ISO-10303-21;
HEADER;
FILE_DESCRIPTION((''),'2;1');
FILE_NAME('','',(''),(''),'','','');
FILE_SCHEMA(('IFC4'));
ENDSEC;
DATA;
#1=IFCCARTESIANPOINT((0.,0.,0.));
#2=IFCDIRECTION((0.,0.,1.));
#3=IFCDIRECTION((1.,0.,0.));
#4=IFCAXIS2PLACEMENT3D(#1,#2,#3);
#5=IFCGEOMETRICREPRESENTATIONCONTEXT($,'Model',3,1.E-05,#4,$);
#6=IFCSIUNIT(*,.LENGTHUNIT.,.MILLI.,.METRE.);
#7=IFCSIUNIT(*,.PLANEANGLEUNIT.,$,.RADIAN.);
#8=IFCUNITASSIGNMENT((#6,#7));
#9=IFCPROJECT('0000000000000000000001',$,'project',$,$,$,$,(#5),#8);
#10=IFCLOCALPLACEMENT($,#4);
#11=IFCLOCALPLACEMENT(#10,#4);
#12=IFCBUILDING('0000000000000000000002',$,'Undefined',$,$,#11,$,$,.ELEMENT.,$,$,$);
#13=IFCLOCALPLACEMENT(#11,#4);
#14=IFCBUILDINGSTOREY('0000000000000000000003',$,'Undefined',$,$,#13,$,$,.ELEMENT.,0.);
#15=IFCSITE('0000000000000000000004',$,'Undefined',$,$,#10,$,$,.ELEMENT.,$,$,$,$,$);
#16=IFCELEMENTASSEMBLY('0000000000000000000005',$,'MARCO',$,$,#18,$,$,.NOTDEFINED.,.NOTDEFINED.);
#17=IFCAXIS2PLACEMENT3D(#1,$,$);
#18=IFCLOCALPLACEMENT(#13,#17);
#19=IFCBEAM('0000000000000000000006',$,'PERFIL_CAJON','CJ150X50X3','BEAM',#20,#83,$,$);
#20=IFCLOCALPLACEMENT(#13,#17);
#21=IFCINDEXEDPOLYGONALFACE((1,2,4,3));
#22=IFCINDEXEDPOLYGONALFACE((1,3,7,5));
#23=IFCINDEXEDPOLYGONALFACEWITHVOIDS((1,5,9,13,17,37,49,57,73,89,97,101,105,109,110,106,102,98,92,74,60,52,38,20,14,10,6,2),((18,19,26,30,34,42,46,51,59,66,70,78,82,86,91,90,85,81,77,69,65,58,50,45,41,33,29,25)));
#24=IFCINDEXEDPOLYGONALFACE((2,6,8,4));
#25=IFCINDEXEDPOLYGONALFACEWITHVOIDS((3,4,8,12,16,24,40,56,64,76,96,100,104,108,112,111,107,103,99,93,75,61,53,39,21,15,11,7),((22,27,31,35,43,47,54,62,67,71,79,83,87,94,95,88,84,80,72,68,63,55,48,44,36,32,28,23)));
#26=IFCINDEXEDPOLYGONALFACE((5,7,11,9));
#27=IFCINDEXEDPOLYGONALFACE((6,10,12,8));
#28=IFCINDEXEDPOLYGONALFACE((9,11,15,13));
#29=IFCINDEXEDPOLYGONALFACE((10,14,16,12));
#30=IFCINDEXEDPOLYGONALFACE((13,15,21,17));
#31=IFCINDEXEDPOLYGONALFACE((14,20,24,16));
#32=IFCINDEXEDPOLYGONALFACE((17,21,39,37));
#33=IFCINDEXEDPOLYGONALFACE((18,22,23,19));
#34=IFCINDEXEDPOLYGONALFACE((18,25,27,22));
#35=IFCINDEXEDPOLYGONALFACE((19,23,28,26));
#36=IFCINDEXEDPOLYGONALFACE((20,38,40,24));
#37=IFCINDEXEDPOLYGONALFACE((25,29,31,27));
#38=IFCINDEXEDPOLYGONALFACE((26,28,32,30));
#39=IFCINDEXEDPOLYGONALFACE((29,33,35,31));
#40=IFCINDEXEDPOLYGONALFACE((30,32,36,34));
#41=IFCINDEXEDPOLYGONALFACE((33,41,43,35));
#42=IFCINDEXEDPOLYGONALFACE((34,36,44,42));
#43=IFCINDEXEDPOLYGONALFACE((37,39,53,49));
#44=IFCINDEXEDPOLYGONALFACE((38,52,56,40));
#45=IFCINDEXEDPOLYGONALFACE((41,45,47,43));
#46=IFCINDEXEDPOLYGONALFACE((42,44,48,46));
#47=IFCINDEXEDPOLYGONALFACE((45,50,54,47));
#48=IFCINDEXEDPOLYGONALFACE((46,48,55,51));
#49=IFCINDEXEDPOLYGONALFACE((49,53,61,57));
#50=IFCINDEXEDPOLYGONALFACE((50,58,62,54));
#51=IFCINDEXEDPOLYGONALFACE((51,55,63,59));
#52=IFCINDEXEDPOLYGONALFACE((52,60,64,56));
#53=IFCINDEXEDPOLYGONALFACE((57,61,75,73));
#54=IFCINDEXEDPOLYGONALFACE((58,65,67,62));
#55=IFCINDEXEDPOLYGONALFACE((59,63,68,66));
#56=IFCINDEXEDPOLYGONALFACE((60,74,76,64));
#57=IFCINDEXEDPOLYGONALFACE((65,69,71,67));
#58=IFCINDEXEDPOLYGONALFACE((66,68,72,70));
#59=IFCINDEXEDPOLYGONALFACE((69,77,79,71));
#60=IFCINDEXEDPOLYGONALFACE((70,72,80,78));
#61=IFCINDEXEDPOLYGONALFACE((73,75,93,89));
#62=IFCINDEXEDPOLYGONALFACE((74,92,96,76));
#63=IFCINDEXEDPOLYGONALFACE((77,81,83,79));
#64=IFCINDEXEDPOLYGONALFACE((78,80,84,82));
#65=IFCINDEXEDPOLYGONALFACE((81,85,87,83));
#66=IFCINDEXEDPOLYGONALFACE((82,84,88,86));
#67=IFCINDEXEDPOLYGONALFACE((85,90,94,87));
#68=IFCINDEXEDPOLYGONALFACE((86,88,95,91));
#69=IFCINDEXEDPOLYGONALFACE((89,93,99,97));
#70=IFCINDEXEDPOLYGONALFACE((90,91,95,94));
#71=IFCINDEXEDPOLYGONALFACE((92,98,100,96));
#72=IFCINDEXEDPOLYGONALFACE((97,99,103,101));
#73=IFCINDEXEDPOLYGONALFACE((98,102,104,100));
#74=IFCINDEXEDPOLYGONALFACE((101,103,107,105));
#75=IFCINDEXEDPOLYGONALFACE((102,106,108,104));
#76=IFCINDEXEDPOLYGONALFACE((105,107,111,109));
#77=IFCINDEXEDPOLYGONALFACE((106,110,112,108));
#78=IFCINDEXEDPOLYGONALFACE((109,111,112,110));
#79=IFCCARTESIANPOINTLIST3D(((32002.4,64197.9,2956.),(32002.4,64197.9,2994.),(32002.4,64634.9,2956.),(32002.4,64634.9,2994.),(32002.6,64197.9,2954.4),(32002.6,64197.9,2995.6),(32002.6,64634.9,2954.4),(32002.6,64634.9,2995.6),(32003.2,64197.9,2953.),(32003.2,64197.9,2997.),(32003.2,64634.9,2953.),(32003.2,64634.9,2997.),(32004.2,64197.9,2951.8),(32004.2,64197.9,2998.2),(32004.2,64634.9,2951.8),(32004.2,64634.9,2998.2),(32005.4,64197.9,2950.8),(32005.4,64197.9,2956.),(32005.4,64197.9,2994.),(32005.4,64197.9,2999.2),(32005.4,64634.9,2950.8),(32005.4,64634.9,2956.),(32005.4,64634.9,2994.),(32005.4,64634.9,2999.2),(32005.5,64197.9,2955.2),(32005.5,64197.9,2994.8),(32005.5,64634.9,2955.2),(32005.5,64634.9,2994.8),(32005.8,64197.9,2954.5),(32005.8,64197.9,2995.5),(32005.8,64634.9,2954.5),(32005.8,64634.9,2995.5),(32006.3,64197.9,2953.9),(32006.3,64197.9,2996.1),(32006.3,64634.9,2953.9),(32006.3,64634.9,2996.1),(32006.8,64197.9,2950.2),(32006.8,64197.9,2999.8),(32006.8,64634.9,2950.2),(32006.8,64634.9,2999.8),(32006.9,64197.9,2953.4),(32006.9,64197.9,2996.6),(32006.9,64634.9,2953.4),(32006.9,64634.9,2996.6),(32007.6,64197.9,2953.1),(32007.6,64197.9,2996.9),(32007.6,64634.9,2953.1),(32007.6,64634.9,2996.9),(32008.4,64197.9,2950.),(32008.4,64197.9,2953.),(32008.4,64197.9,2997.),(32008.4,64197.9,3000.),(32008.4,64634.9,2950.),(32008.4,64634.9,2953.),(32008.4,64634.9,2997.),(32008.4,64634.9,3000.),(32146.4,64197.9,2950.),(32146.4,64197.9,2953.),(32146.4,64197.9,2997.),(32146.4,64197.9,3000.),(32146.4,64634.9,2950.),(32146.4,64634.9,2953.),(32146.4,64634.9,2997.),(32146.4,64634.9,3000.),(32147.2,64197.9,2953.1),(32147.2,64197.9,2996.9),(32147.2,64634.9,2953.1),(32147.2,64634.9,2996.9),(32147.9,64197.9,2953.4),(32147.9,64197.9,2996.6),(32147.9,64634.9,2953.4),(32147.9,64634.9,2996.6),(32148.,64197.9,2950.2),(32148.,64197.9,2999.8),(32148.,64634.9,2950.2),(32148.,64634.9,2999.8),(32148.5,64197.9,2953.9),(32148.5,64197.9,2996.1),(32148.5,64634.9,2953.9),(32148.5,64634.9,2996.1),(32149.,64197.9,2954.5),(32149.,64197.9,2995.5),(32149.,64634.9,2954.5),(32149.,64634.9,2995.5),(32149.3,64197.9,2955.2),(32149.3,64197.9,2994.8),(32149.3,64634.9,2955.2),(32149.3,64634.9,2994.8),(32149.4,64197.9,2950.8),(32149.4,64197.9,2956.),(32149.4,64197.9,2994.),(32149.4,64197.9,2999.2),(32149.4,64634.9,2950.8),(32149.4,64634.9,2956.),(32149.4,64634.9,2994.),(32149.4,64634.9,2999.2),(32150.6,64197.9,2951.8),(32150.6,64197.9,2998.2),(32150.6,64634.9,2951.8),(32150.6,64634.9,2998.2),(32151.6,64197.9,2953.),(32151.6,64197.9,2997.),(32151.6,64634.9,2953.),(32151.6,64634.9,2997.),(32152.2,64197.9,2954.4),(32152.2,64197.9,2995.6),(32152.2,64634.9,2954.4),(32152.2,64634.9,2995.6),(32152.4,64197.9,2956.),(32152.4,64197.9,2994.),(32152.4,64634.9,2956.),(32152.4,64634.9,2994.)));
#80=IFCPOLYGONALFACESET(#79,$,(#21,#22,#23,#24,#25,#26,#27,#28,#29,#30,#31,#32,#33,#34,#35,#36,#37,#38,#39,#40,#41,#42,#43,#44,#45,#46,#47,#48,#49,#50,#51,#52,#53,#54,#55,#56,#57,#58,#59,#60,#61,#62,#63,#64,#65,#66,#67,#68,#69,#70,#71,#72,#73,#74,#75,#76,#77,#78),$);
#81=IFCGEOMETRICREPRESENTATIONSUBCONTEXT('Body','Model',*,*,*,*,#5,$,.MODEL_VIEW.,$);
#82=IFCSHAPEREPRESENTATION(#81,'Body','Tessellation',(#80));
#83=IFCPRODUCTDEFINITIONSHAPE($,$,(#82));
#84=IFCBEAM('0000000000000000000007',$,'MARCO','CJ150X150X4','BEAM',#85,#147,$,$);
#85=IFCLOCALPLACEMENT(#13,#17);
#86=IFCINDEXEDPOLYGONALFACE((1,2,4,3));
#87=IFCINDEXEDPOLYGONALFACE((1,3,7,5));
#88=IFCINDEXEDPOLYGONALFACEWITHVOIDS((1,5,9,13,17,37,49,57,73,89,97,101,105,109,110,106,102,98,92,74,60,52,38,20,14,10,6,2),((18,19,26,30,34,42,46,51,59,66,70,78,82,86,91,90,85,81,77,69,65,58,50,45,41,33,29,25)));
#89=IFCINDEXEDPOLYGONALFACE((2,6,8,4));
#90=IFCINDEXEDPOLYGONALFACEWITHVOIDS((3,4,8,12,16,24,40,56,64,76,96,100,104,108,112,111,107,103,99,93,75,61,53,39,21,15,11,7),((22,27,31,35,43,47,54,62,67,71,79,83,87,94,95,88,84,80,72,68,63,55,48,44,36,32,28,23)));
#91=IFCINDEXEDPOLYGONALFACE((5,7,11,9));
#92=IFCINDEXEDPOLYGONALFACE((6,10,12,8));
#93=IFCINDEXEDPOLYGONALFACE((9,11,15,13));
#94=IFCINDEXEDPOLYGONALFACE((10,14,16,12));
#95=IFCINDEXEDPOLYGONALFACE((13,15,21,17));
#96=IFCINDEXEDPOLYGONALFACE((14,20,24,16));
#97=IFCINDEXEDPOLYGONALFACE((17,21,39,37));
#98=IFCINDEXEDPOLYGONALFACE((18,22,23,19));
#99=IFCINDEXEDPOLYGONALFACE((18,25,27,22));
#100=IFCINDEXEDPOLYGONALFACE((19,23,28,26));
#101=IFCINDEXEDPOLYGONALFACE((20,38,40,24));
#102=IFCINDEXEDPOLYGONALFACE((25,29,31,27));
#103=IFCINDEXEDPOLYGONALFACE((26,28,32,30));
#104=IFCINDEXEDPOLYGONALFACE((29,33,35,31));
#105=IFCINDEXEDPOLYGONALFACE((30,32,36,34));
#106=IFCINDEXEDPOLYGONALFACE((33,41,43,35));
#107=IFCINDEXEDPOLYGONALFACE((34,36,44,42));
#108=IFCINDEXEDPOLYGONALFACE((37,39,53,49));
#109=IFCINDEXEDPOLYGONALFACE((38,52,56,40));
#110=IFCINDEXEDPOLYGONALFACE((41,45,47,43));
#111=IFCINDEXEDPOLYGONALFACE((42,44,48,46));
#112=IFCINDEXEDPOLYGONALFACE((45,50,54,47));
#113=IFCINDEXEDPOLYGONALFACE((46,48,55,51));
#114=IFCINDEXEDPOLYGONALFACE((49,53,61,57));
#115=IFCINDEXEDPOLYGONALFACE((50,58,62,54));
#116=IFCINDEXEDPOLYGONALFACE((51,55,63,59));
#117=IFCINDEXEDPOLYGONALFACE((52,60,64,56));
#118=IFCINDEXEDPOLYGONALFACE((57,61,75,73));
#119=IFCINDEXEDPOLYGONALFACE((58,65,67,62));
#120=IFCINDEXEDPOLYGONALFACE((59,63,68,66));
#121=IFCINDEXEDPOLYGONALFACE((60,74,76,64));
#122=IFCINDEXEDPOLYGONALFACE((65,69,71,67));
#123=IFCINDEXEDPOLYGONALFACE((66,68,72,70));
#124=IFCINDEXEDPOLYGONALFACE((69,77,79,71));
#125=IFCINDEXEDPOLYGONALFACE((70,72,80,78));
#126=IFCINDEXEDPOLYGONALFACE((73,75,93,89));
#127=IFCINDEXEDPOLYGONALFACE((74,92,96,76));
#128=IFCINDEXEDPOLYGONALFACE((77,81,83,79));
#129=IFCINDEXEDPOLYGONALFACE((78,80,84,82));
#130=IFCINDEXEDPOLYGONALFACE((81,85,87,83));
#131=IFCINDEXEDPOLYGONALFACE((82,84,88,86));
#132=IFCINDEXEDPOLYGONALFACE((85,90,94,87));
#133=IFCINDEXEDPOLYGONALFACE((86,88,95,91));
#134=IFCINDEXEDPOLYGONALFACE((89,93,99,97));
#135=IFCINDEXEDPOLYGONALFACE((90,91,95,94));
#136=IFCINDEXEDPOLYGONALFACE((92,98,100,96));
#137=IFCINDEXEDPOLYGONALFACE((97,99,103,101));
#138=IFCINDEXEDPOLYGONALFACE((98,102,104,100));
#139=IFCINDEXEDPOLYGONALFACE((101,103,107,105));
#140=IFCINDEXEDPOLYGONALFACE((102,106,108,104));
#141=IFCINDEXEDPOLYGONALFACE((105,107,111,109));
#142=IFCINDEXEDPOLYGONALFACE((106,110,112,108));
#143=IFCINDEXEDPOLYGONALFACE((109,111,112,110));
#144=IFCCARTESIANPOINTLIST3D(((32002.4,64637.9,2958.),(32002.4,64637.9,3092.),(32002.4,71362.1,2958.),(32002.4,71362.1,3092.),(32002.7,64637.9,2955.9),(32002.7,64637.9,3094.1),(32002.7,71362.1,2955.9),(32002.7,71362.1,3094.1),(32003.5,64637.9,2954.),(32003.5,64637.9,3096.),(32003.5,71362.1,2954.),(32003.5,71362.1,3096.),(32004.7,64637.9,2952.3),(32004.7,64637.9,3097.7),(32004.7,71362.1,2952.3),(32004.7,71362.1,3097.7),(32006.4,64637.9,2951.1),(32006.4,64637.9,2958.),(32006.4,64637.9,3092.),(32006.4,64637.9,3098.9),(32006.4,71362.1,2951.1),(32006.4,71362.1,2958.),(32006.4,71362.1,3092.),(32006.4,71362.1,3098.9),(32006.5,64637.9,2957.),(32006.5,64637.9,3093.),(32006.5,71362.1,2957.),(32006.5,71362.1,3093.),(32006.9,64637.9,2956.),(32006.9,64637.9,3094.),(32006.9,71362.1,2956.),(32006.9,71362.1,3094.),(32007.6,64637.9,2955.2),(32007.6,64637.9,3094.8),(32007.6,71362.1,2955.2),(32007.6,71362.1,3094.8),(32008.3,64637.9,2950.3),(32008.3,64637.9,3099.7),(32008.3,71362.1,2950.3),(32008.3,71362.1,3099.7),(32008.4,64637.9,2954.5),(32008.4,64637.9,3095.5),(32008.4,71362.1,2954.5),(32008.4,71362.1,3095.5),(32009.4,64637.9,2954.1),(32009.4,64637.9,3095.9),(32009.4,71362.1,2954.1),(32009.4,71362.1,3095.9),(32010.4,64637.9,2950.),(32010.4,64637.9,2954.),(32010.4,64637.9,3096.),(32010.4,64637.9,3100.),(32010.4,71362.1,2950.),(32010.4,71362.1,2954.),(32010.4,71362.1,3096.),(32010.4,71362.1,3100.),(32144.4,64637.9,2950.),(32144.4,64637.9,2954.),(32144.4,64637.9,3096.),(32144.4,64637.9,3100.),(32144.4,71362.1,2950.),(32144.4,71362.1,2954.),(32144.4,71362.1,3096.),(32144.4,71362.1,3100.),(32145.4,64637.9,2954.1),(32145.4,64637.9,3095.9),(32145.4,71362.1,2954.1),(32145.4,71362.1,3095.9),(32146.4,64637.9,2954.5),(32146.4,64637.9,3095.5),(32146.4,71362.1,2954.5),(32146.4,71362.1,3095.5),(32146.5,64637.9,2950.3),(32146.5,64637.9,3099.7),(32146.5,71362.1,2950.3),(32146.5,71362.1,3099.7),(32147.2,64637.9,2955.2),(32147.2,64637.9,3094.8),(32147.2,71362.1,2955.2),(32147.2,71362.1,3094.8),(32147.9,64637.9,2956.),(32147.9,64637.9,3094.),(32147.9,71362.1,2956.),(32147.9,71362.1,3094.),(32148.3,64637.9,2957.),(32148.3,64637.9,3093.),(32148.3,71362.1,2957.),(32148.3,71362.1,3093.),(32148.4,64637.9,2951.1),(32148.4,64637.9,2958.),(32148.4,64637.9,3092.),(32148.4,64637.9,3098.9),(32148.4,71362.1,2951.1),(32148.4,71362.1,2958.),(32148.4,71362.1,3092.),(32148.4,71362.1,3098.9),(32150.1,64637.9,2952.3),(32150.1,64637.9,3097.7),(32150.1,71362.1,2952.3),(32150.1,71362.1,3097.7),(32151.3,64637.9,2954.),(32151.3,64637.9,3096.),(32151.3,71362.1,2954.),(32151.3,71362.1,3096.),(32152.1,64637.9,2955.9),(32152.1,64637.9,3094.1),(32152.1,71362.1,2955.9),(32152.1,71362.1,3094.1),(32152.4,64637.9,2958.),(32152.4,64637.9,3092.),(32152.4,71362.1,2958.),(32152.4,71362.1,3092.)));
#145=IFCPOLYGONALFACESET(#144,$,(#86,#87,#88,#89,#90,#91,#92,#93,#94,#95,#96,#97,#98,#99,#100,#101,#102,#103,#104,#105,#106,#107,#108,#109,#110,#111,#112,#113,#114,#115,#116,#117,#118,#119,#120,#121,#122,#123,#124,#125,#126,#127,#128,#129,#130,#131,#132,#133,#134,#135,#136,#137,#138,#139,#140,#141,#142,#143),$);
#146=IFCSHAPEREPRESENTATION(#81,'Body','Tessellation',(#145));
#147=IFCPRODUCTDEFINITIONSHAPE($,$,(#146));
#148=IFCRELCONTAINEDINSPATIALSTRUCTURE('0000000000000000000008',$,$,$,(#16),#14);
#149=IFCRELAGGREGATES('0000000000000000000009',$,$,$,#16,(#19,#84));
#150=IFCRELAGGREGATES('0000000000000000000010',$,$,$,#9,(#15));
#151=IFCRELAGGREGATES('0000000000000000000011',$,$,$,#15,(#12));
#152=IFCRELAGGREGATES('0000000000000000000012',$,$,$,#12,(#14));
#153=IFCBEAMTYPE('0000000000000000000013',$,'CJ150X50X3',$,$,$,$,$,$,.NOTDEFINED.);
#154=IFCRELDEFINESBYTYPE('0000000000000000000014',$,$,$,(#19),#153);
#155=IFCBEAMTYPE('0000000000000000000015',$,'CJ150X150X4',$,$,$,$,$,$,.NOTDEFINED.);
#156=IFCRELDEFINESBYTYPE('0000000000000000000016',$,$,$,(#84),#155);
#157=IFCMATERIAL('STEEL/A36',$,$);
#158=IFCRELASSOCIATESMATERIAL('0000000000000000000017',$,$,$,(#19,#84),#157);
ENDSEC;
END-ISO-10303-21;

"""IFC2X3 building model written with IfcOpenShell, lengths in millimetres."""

from ifc_helpers import new_model, si_unit, frame, origin_with_axes, origin_2d_with_axis, place, context, subcontext, project, spatial, hollow_rectangle, extrude, material, type_object, element, aggregate, save


model = new_model("IFC2X3")

# Units and contexts
model_context = context("Model", 3, precision=1e-05, world=origin_with_axes())
body_context = subcontext(model_context, "Body", "Model", "MODEL_VIEW")
ifc_project = project(units=[si_unit("LENGTHUNIT", "METRE", prefix="MILLI"), si_unit("PLANEANGLEUNIT", "RADIAN")], contexts=[model_context])

# Site, building, storey
site_placement = place(None, origin_with_axes())
site = spatial("IfcSite", under=ifc_project, at=site_placement, Name="Undefined", CompositionType="ELEMENT")
building_placement = place(site_placement, origin_with_axes())
building = spatial("IfcBuilding", under=site, at=building_placement, Name="Undefined", CompositionType="ELEMENT")
storey_placement = place(building_placement, origin_with_axes())
storey = spatial("IfcBuildingStorey", under=building, at=storey_placement, Name="Undefined", CompositionType="ELEMENT", Elevation=0.0)

# Element assembly, beams
assembly_1_placement = place(storey_placement, origin_with_axes())
assembly_1 = element("IfcElementAssembly", 1, at=assembly_1_placement, inside=storey, Name="MARCO", AssemblyPlace="NOTDEFINED", PredefinedType="NOTDEFINED")
ifc_material_1 = material(Name="STEEL/A36")
beam_type_1 = type_object("IfcBeamType", Name="CJ150X50X3", PredefinedType="NOTDEFINED")
beam_1_placement = place(assembly_1_placement, frame((32077.4, 64634.9, 2975.0), z_axis=(1.0, 0.0, 0.0), x_axis=(0.0, -1.0, 0.0)))
beam_1 = element("IfcBeam", 2, at=beam_1_placement, type_object=beam_type_1, material=ifc_material_1, Name="PERFIL_CAJON", Description="CJ150X50X3", ObjectType="BEAM", context=body_context, shape_type="SweptSolid", body=[
    extrude(hollow_rectangle(XDim=50.0, YDim=150.0, WallThickness=3.0, InnerFilletRadius=3.0, OuterFilletRadius=6.0, at=origin_2d_with_axis()), frame((437.0, 0.0, 0.0), z_axis=(-1.0, 0.0, 0.0), x_axis=(0.0, -1.0, 0.0)), (0.0, 0.0, 1.0), 437.0),
])
beam_type_2 = type_object("IfcBeamType", Name="CJ150X150X4", PredefinedType="NOTDEFINED")
beam_2_placement = place(assembly_1_placement, frame((32077.4, 64637.9, 3025.0), z_axis=(0.0, 0.0, 1.0), x_axis=(0.0, 1.0, 0.0)))
beam_2 = element("IfcBeam", 3, at=beam_2_placement, type_object=beam_type_2, material=ifc_material_1, Name="MARCO", Description="CJ150X150X4", ObjectType="BEAM", context=body_context, shape_type="SweptSolid", body=[
    extrude(hollow_rectangle(XDim=150.0, YDim=150.0, WallThickness=4.0, InnerFilletRadius=4.0, OuterFilletRadius=8.0, at=origin_2d_with_axis()), frame((6724.2, 0.0, 0.0), z_axis=(-1.0, 0.0, 0.0), x_axis=(0.0, -1.0, 0.0)), (0.0, 0.0, 1.0), 6724.2),
])

aggregate(assembly_1, [beam_1, beam_2])

save(model, "model.ifc")
